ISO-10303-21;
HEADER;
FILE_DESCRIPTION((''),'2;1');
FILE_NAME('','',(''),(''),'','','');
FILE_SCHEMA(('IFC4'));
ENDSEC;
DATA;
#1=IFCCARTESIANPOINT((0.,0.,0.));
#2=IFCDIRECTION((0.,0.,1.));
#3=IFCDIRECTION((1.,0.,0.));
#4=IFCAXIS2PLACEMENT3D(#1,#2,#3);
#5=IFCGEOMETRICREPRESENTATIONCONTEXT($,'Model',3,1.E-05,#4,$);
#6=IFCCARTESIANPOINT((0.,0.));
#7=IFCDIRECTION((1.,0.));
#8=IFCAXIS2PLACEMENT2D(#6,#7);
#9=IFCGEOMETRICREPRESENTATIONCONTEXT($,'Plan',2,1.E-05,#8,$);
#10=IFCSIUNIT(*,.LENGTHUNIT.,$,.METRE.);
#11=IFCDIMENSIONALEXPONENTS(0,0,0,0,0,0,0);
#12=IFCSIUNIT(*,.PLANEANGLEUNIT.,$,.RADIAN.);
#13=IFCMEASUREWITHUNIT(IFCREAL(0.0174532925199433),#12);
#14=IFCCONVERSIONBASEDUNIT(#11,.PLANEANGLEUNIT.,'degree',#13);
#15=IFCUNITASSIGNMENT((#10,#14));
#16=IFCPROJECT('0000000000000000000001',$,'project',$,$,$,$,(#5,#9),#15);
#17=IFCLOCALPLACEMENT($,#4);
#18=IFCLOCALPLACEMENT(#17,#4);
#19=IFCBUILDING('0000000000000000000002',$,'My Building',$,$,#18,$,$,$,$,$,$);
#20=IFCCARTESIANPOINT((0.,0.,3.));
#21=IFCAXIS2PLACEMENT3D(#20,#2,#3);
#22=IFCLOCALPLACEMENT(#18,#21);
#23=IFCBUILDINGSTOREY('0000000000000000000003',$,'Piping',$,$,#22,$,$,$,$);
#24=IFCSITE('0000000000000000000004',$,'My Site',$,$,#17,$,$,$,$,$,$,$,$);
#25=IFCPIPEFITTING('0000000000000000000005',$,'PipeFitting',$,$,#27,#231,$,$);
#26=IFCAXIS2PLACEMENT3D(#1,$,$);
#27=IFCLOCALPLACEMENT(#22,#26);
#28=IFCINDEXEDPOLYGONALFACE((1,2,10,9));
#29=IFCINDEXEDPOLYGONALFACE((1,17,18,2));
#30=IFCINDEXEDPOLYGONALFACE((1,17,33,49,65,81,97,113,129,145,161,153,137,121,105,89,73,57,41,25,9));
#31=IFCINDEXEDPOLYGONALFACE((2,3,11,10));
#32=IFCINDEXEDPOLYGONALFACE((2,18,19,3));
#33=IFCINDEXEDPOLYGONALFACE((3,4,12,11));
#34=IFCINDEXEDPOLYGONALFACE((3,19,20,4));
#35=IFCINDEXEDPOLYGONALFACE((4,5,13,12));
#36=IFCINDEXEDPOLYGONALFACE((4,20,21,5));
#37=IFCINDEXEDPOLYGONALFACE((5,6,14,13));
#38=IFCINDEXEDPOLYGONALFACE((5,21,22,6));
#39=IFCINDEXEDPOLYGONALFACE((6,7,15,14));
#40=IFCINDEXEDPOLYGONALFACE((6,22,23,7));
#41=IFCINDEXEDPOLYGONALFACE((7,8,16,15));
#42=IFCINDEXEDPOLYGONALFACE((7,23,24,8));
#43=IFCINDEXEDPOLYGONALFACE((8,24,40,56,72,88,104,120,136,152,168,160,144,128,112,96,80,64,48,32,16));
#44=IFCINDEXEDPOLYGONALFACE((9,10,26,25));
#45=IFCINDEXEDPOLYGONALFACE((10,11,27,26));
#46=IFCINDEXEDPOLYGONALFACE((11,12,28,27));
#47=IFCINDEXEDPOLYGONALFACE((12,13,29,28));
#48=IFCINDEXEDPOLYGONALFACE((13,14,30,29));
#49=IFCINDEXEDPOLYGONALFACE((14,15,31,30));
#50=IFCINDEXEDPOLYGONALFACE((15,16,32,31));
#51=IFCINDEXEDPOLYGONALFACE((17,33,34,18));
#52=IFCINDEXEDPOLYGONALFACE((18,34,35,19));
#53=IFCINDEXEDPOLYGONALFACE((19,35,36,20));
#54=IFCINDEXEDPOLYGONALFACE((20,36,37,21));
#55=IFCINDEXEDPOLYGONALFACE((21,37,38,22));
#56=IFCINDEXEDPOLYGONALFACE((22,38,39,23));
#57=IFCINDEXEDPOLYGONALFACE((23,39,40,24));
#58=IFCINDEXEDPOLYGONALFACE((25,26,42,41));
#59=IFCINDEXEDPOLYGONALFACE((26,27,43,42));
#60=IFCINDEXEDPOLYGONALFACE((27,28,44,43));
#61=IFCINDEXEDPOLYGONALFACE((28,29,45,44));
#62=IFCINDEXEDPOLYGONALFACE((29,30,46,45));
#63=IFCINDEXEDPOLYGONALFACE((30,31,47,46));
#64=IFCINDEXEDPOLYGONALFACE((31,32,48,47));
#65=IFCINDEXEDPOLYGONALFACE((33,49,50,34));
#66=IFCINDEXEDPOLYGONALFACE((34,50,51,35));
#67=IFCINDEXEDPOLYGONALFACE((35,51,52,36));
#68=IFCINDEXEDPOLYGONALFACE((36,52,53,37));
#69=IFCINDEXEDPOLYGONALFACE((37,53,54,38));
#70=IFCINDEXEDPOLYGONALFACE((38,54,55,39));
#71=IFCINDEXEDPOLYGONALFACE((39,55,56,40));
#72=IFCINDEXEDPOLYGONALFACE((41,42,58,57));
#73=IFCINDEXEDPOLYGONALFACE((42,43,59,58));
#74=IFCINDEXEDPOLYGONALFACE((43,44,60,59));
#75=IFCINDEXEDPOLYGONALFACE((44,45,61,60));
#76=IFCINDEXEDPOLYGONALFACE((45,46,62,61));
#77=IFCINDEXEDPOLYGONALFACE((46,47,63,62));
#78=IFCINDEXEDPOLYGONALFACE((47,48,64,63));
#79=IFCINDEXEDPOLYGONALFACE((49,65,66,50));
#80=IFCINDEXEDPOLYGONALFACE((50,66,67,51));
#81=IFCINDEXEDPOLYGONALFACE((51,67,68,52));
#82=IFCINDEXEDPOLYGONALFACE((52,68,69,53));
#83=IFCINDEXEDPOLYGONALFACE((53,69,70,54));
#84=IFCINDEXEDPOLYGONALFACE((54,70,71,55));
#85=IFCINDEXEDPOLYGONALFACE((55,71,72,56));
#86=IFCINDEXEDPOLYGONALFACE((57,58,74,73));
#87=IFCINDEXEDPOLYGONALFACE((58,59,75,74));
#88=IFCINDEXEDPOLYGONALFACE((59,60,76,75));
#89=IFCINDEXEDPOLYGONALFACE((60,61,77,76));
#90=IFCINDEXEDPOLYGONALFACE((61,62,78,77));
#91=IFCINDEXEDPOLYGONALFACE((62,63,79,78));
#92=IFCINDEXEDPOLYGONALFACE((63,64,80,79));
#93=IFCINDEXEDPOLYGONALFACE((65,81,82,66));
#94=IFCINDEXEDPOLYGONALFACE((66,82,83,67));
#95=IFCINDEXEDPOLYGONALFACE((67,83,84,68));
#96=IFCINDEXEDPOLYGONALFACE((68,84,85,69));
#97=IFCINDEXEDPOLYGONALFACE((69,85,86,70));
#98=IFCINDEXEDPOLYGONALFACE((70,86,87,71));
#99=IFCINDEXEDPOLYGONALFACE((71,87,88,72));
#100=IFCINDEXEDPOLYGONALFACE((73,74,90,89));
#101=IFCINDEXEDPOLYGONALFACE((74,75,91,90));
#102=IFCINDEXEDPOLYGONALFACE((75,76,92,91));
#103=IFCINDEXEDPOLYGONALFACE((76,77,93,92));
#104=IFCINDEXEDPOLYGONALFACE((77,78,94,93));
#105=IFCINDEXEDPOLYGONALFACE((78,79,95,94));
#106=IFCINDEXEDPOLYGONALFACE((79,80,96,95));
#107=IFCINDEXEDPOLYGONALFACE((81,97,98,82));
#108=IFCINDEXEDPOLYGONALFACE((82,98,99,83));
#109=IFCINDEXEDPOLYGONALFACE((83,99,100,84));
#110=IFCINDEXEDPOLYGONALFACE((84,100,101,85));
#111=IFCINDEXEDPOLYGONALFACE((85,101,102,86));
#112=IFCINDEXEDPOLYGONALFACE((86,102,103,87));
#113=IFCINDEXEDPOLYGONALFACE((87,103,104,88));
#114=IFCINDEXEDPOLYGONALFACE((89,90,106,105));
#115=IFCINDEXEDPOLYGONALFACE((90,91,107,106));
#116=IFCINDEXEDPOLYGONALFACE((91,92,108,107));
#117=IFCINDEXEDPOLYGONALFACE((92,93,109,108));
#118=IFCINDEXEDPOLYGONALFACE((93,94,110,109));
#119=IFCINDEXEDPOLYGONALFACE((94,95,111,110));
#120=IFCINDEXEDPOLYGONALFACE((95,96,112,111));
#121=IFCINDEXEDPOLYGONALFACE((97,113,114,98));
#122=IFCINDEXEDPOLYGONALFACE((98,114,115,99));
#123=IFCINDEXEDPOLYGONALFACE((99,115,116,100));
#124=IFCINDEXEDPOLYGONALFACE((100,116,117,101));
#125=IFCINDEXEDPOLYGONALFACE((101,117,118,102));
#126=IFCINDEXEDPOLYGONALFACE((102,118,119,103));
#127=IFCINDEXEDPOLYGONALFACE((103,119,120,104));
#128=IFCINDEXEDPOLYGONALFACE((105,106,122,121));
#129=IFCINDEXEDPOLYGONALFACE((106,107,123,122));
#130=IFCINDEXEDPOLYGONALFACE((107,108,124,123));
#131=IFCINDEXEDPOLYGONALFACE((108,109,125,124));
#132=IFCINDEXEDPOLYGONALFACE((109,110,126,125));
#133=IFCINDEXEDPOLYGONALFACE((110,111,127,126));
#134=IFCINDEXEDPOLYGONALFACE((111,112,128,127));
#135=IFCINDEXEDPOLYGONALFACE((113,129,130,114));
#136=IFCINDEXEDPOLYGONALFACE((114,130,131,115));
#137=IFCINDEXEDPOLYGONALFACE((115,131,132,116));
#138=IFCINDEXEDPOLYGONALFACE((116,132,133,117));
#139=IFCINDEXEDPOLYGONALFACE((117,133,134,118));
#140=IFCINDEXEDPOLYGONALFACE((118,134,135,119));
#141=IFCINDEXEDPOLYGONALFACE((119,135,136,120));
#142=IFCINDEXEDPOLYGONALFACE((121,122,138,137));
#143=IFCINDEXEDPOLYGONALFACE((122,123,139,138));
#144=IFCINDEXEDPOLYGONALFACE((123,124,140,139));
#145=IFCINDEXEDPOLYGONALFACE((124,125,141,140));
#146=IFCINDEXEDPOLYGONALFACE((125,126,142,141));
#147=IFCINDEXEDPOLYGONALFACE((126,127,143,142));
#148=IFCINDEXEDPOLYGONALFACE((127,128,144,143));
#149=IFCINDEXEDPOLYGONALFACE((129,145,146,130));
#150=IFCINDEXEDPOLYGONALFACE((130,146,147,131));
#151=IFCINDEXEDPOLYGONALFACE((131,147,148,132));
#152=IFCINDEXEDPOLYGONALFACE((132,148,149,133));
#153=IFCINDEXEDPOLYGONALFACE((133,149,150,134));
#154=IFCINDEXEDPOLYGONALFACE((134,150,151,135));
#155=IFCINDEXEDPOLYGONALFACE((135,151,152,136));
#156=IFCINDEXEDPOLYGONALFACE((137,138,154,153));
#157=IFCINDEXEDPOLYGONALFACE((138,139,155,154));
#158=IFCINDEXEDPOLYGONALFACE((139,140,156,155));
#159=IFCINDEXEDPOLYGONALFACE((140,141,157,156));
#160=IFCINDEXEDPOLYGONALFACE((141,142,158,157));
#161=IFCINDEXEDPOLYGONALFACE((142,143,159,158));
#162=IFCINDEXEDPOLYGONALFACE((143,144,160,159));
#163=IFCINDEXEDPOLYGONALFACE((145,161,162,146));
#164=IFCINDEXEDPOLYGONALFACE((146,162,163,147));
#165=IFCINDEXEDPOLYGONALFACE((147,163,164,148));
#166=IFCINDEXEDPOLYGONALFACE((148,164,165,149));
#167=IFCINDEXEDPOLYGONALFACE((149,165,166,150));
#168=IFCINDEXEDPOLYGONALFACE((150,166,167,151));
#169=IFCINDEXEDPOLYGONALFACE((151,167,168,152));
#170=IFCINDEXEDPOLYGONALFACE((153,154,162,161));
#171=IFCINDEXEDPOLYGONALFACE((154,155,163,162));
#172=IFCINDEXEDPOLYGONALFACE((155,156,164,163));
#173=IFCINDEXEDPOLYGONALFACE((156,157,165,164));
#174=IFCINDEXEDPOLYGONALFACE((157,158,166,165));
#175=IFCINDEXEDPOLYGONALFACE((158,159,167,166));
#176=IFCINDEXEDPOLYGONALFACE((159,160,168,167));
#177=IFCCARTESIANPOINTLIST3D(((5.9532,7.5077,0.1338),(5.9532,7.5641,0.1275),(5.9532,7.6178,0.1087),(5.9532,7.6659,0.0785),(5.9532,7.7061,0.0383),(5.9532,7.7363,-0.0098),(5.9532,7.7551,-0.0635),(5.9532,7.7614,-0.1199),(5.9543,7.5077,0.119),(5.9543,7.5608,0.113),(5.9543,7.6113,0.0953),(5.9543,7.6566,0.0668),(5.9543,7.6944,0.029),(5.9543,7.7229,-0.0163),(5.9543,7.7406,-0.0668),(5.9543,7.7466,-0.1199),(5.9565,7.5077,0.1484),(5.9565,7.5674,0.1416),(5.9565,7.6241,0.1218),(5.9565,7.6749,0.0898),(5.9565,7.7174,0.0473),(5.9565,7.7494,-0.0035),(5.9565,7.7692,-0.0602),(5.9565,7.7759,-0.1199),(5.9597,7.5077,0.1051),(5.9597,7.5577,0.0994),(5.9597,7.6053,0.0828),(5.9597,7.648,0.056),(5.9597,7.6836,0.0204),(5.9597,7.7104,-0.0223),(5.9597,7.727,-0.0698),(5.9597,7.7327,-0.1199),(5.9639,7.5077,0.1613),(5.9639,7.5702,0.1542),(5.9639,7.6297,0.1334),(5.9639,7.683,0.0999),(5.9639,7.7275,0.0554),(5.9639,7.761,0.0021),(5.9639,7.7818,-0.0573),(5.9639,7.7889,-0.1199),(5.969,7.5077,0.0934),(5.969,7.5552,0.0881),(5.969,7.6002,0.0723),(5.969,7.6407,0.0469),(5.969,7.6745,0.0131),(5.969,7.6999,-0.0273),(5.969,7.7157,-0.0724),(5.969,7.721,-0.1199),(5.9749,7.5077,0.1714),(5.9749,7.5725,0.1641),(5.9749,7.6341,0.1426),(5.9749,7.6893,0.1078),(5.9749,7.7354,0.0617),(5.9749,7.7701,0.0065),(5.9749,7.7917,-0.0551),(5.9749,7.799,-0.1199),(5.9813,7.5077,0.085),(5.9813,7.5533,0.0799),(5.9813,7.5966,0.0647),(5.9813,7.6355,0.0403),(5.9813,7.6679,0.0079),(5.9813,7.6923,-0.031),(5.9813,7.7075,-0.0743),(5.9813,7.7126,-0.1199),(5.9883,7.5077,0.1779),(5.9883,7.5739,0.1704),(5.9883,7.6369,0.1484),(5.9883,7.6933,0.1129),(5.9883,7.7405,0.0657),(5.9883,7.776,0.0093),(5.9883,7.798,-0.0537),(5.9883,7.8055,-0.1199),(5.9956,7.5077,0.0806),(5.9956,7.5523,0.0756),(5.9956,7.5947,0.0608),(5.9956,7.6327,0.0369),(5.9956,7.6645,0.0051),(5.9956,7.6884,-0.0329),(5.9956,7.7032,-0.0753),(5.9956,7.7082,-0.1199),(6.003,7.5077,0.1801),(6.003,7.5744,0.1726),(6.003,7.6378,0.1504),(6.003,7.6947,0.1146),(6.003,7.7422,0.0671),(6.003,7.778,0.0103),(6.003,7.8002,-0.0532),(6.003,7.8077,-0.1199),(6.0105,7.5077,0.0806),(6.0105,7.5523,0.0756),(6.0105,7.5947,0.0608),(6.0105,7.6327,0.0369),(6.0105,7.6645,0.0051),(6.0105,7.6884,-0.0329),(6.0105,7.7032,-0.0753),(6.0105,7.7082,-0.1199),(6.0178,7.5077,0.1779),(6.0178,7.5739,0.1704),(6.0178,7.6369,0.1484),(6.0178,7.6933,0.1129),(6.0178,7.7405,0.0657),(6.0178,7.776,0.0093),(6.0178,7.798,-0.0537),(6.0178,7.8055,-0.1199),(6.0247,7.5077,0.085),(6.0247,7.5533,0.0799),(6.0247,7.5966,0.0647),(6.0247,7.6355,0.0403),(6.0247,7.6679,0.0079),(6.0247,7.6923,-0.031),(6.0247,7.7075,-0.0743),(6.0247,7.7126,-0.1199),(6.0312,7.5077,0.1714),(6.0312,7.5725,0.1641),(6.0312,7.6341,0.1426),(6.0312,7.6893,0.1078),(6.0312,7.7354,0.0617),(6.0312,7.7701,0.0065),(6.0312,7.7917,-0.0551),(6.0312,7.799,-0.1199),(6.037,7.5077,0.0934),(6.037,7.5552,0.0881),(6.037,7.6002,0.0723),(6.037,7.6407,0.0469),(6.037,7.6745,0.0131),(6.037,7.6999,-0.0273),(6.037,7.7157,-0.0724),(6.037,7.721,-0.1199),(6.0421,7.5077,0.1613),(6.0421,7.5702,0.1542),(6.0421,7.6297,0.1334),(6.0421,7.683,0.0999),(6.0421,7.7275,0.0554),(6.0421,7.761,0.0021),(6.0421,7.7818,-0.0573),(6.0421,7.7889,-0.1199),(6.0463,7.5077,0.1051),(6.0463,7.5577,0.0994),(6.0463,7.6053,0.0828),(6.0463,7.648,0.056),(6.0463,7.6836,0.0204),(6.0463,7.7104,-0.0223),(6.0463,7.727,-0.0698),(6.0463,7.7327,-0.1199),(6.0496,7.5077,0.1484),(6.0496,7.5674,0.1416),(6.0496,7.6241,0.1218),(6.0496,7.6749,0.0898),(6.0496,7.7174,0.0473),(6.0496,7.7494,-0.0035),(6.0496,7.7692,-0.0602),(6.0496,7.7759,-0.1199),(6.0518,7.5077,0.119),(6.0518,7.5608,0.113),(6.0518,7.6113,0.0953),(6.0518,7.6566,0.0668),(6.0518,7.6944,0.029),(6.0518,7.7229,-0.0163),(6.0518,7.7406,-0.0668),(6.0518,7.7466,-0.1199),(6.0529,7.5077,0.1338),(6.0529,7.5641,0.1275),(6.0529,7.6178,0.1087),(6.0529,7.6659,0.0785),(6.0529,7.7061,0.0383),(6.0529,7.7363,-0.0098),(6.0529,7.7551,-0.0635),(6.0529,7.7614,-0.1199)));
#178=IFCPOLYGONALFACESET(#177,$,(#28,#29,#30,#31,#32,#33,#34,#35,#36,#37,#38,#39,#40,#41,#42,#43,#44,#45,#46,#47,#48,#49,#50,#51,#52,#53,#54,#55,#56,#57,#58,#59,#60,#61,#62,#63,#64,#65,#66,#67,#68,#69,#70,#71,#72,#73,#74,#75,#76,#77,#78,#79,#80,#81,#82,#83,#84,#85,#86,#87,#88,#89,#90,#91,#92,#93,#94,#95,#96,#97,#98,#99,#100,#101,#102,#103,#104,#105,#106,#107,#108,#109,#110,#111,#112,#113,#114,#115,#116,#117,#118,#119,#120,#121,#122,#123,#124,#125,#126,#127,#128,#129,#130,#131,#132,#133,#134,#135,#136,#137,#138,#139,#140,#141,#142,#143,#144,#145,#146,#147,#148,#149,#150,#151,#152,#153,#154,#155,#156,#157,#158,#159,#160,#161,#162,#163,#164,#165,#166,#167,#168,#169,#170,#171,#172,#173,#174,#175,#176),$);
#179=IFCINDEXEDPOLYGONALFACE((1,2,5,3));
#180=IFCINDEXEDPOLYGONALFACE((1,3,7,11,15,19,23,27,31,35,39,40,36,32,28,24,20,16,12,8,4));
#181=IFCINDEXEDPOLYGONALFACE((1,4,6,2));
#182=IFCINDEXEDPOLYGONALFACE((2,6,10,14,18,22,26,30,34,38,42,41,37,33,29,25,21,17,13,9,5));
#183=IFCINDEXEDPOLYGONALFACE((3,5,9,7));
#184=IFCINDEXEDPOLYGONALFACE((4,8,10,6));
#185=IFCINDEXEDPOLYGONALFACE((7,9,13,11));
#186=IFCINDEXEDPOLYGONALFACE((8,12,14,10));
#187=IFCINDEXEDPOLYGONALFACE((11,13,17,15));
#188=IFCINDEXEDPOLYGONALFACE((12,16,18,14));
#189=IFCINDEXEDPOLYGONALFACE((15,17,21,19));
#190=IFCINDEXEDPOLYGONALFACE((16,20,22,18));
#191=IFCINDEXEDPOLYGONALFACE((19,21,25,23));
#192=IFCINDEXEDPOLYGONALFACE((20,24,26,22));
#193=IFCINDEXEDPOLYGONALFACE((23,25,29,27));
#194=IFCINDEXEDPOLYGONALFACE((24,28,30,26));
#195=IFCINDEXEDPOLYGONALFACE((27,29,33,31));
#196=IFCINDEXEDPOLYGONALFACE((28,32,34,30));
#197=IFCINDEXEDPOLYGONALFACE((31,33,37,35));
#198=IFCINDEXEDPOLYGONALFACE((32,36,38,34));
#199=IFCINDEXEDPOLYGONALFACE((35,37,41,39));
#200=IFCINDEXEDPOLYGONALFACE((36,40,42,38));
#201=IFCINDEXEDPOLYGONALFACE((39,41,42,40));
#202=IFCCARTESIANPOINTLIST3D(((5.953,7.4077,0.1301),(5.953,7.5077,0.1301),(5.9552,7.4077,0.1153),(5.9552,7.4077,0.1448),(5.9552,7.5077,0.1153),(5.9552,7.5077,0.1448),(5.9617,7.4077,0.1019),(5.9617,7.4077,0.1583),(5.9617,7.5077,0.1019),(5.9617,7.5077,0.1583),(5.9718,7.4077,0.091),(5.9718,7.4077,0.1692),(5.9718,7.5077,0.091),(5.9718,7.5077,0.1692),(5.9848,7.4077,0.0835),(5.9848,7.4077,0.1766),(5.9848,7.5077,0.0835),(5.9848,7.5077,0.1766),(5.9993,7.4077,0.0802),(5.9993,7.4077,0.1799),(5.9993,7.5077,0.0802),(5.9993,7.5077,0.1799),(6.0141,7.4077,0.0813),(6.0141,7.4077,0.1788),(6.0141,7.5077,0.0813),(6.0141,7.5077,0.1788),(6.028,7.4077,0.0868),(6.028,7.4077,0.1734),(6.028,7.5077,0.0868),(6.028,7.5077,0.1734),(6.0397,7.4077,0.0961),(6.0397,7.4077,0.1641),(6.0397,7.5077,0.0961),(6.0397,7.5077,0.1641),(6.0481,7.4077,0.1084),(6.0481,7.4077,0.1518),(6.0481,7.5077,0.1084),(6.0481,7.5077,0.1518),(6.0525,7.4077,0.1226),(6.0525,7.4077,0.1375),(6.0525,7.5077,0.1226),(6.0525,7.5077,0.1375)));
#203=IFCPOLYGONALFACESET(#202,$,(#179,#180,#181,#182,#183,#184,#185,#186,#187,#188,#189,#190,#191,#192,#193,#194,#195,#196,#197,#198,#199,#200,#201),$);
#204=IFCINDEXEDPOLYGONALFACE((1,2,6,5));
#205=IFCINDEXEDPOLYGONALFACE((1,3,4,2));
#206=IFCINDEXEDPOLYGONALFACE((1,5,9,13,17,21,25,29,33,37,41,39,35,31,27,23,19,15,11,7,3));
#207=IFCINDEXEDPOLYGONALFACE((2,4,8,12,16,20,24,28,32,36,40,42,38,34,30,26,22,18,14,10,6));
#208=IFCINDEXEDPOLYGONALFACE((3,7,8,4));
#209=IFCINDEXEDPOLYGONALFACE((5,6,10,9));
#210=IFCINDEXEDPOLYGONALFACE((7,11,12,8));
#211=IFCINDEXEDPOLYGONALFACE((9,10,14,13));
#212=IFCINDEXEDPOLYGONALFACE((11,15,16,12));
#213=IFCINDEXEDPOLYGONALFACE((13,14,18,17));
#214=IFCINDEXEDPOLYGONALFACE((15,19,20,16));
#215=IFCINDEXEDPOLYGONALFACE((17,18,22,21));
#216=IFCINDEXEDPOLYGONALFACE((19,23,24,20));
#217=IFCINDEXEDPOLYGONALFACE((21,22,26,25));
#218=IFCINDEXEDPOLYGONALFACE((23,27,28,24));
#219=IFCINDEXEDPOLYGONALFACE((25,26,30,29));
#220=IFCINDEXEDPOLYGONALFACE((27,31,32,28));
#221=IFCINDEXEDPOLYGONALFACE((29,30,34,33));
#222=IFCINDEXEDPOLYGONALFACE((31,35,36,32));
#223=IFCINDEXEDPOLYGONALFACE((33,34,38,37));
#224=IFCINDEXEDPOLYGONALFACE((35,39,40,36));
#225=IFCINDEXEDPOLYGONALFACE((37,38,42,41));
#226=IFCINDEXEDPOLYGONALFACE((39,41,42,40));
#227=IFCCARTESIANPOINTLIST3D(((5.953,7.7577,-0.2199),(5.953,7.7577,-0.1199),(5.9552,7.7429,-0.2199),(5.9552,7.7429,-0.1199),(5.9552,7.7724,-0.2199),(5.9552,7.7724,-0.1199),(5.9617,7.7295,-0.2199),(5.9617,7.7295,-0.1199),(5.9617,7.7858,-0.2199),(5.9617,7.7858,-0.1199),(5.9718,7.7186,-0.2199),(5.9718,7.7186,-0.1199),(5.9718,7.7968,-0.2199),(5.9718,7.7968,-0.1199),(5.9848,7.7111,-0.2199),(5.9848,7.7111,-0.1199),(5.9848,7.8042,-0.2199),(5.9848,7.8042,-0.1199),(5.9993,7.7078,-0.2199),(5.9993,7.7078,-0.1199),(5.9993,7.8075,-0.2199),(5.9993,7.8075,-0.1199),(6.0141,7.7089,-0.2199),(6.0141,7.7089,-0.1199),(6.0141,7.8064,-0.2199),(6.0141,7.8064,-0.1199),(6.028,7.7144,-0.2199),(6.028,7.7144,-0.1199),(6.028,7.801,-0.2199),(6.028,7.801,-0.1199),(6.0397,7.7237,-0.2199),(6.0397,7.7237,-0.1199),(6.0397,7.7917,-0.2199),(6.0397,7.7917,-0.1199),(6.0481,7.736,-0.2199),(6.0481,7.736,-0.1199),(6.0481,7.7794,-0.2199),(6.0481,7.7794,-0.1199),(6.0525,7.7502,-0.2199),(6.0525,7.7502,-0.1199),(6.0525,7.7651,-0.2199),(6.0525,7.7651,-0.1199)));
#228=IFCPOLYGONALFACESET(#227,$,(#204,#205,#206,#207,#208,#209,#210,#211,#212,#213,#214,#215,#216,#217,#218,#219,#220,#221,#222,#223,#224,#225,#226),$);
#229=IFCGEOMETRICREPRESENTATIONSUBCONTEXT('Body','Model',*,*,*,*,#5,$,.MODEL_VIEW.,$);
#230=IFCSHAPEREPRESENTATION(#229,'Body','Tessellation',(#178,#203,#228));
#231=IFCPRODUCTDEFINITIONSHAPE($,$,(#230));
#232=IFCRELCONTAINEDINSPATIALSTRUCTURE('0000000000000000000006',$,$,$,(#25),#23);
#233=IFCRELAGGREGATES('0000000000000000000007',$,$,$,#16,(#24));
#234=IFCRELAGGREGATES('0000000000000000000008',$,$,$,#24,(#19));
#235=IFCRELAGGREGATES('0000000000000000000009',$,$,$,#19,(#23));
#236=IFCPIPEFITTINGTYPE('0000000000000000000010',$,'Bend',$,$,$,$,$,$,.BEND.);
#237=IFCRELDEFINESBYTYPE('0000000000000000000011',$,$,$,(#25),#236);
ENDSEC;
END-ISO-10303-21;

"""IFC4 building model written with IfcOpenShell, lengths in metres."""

from ifc_helpers import new_model, entity, si_unit, converted_unit, frame, origin_with_axes, origin_2d_with_axis, place, context, subcontext, project, spatial, circle, extrude, source, transform, mapped, type_object, type_shapes, element, save


model = new_model("IFC4")

# Units and contexts
model_context = context("Model", 3, precision=1e-05, world=origin_with_axes())
plan_context = context("Plan", 2, precision=1e-05, world=origin_2d_with_axis())
body_context = subcontext(model_context, "Body", "Model", "MODEL_VIEW")
ifc_project = project(units=[si_unit("LENGTHUNIT", "METRE"), converted_unit("PLANEANGLEUNIT", "degree", entity("IfcReal", 0.0174532925199433), si_unit("PLANEANGLEUNIT", "RADIAN"), dimensions=[0, 0, 0, 0, 0, 0, 0])], contexts=[model_context, plan_context])

# Site, building, storey
site_placement = place(None, origin_with_axes())
site = spatial("IfcSite", under=ifc_project, at=site_placement, Name="My Site")
building_placement = place(site_placement, origin_with_axes())
building = spatial("IfcBuilding", under=site, at=building_placement, Name="My Building")
storey_placement = place(building_placement, frame((0.0, 0.0, 3.0), z_axis=(0.0, 0.0, 1.0), x_axis=(1.0, 0.0, 0.0)))
storey = spatial("IfcBuildingStorey", under=building, at=storey_placement, Name="Piping")

# Pipe fitting
pipe_fitting_type_1 = type_object("IfcPipeFittingType", Name="Bend", PredefinedType="BEND")
shared_shape_1 = source(origin_with_axes(), body_context, "Body", "SolidModel", [
    entity("IfcSweptDiskSolid", entity("IfcIndexedPolyCurve", entity("IfcCartesianPointList3D", [[0.0, 0.0, 0.1], [0.0, -0.0732, 0.2768], [0.0, -0.25, 0.35]]), [entity("IfcArcIndex", [1, 2, 3])]), 0.05),
    extrude(circle(Radius=0.05), origin_with_axes(), (0.0, 0.0, 1.0), 0.1),
    extrude(circle(Radius=0.05), frame((0.0, -0.25, 0.35), z_axis=(0.0, -1.0, -0.000015), x_axis=(1.0, 0.0, 0.0)), (0.0, 0.0, 1.0), 0.1),
])
type_shapes(pipe_fitting_type_1, [shared_shape_1])
for number, where, z_axis, x_axis, name in (
    (1, (6.003, 7.4077, 0.1301), (0.0, 1.0, 0.000015), (-1.0, 0.0, 0.0), "PipeFitting"),
):
    element("IfcPipeFitting", number, at=place(storey_placement, frame(where, z_axis=z_axis, x_axis=x_axis)), inside=storey, type_object=pipe_fitting_type_1, Name=name, context=body_context, shape_type="MappedRepresentation", body=[
        mapped(shared_shape_1, transform((0.0, 0.0, 0.0), x_axis=(1.0, 0.0, 0.0), y_axis=(0.0, 1.0, 0.0), z_axis=(0.0, 0.0, 1.0), scale=1.0)),
    ])

save(model, "model.ifc")
